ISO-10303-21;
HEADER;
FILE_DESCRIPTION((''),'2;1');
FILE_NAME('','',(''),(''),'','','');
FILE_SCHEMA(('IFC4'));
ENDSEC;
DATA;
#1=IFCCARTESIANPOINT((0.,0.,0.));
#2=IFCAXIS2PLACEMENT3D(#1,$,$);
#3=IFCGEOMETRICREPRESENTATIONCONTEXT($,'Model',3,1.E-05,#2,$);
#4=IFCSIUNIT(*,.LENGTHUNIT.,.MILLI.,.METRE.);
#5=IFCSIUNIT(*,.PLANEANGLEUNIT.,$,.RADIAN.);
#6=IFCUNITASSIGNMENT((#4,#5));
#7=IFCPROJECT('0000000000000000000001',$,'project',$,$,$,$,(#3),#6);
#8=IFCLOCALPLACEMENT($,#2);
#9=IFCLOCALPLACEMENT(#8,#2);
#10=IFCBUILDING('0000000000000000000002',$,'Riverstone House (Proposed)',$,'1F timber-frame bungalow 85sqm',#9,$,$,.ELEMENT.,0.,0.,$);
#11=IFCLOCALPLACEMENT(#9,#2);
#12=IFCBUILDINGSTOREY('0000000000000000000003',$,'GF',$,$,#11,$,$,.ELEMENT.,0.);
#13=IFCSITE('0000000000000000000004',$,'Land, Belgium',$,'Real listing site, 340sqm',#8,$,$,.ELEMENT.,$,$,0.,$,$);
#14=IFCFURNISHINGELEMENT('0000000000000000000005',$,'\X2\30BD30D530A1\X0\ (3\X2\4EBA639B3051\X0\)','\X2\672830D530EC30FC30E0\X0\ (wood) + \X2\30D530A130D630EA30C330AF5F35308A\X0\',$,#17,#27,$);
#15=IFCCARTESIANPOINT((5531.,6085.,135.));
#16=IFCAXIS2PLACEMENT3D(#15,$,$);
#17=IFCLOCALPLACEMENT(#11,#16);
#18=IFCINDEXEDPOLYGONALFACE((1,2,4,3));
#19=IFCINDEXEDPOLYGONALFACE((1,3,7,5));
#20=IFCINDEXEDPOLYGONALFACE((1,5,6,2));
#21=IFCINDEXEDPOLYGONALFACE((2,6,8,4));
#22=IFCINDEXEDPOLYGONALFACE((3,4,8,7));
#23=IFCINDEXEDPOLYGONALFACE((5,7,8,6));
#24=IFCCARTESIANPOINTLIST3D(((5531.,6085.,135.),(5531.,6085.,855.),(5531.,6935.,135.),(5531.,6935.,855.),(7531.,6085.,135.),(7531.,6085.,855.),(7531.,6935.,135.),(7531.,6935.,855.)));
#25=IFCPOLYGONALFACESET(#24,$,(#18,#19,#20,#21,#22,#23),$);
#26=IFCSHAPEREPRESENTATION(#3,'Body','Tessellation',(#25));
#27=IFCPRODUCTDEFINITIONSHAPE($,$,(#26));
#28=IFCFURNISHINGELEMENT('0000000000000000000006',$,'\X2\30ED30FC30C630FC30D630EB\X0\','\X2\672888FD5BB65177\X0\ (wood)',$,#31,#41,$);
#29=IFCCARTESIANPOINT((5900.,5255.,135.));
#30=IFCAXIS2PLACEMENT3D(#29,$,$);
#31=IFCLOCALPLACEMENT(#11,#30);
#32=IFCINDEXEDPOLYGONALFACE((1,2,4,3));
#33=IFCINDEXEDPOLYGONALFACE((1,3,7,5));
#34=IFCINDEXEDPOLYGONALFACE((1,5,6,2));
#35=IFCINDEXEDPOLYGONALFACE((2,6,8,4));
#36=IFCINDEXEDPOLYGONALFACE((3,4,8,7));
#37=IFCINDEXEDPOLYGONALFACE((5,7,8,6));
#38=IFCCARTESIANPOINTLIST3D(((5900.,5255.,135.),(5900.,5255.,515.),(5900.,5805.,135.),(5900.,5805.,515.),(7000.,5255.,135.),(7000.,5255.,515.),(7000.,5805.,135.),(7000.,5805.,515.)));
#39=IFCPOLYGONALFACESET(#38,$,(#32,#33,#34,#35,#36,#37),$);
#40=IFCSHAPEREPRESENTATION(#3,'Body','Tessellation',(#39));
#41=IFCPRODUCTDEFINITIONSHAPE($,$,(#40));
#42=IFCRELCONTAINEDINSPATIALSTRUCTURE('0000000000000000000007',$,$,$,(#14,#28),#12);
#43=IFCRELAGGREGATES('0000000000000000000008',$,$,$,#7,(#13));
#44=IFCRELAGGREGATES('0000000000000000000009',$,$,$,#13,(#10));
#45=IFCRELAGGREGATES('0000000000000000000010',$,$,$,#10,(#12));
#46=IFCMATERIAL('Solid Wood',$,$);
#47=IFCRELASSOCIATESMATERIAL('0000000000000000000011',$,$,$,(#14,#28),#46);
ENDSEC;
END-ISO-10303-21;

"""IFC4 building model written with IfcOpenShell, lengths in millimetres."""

from ifc_helpers import new_model, si_unit, frame, frame_2d, origin, place, context, project, spatial, rectangle, extrude, material, element, save


model = new_model("IFC4")

# Units and contexts
model_context = context("Model", 3, precision=1e-05, world=origin())
ifc_project = project(units=[si_unit("LENGTHUNIT", "METRE", prefix="MILLI"), si_unit("PLANEANGLEUNIT", "RADIAN")], contexts=[model_context])

# Site, building, storey
site_placement = place(None, origin())
site = spatial("IfcSite", under=ifc_project, at=site_placement, Name="Land, Belgium", ObjectType="Real listing site, 340sqm", CompositionType="ELEMENT", RefElevation=0.0)
building_placement = place(site_placement, origin())
building = spatial("IfcBuilding", under=site, at=building_placement, Name="Riverstone House (Proposed)", ObjectType="1F timber-frame bungalow 85sqm", CompositionType="ELEMENT", ElevationOfRefHeight=0.0, ElevationOfTerrain=0.0)
storey_placement = place(building_placement, origin())
storey = spatial("IfcBuildingStorey", under=building, at=storey_placement, Name="GF", CompositionType="ELEMENT", Elevation=0.0)

# Shared definitions
ifc_material_1 = material(Name="Solid Wood")

# Furnishing elements
furnishing_1_placement = place(storey_placement, frame((5531.0, 6085.0, 135.0)))
element("IfcFurnishingElement", 1, at=furnishing_1_placement, inside=storey, material=ifc_material_1, Name="ソファ (3人掛け)", Description="木フレーム (wood) + ファブリック張り", context=model_context, shape_type="SweptSolid", body=[
    extrude(rectangle(XDim=2000.0, YDim=850.0, at=frame_2d((1000.0, 425.0))), frame((5531.0, 6085.0, 135.0)), (0.0, 0.0, 1.0), 720.0),
])
furnishing_2_placement = place(storey_placement, frame((5900.0, 5255.0, 135.0)))
element("IfcFurnishingElement", 2, at=furnishing_2_placement, inside=storey, material=ifc_material_1, Name="ローテーブル", Description="木製家具 (wood)", context=model_context, shape_type="SweptSolid", body=[
    extrude(rectangle(XDim=1100.0, YDim=550.0, at=frame_2d((550.0, 275.0))), frame((5900.0, 5255.0, 135.0)), (0.0, 0.0, 1.0), 380.0),
])

save(model, "model.ifc")
